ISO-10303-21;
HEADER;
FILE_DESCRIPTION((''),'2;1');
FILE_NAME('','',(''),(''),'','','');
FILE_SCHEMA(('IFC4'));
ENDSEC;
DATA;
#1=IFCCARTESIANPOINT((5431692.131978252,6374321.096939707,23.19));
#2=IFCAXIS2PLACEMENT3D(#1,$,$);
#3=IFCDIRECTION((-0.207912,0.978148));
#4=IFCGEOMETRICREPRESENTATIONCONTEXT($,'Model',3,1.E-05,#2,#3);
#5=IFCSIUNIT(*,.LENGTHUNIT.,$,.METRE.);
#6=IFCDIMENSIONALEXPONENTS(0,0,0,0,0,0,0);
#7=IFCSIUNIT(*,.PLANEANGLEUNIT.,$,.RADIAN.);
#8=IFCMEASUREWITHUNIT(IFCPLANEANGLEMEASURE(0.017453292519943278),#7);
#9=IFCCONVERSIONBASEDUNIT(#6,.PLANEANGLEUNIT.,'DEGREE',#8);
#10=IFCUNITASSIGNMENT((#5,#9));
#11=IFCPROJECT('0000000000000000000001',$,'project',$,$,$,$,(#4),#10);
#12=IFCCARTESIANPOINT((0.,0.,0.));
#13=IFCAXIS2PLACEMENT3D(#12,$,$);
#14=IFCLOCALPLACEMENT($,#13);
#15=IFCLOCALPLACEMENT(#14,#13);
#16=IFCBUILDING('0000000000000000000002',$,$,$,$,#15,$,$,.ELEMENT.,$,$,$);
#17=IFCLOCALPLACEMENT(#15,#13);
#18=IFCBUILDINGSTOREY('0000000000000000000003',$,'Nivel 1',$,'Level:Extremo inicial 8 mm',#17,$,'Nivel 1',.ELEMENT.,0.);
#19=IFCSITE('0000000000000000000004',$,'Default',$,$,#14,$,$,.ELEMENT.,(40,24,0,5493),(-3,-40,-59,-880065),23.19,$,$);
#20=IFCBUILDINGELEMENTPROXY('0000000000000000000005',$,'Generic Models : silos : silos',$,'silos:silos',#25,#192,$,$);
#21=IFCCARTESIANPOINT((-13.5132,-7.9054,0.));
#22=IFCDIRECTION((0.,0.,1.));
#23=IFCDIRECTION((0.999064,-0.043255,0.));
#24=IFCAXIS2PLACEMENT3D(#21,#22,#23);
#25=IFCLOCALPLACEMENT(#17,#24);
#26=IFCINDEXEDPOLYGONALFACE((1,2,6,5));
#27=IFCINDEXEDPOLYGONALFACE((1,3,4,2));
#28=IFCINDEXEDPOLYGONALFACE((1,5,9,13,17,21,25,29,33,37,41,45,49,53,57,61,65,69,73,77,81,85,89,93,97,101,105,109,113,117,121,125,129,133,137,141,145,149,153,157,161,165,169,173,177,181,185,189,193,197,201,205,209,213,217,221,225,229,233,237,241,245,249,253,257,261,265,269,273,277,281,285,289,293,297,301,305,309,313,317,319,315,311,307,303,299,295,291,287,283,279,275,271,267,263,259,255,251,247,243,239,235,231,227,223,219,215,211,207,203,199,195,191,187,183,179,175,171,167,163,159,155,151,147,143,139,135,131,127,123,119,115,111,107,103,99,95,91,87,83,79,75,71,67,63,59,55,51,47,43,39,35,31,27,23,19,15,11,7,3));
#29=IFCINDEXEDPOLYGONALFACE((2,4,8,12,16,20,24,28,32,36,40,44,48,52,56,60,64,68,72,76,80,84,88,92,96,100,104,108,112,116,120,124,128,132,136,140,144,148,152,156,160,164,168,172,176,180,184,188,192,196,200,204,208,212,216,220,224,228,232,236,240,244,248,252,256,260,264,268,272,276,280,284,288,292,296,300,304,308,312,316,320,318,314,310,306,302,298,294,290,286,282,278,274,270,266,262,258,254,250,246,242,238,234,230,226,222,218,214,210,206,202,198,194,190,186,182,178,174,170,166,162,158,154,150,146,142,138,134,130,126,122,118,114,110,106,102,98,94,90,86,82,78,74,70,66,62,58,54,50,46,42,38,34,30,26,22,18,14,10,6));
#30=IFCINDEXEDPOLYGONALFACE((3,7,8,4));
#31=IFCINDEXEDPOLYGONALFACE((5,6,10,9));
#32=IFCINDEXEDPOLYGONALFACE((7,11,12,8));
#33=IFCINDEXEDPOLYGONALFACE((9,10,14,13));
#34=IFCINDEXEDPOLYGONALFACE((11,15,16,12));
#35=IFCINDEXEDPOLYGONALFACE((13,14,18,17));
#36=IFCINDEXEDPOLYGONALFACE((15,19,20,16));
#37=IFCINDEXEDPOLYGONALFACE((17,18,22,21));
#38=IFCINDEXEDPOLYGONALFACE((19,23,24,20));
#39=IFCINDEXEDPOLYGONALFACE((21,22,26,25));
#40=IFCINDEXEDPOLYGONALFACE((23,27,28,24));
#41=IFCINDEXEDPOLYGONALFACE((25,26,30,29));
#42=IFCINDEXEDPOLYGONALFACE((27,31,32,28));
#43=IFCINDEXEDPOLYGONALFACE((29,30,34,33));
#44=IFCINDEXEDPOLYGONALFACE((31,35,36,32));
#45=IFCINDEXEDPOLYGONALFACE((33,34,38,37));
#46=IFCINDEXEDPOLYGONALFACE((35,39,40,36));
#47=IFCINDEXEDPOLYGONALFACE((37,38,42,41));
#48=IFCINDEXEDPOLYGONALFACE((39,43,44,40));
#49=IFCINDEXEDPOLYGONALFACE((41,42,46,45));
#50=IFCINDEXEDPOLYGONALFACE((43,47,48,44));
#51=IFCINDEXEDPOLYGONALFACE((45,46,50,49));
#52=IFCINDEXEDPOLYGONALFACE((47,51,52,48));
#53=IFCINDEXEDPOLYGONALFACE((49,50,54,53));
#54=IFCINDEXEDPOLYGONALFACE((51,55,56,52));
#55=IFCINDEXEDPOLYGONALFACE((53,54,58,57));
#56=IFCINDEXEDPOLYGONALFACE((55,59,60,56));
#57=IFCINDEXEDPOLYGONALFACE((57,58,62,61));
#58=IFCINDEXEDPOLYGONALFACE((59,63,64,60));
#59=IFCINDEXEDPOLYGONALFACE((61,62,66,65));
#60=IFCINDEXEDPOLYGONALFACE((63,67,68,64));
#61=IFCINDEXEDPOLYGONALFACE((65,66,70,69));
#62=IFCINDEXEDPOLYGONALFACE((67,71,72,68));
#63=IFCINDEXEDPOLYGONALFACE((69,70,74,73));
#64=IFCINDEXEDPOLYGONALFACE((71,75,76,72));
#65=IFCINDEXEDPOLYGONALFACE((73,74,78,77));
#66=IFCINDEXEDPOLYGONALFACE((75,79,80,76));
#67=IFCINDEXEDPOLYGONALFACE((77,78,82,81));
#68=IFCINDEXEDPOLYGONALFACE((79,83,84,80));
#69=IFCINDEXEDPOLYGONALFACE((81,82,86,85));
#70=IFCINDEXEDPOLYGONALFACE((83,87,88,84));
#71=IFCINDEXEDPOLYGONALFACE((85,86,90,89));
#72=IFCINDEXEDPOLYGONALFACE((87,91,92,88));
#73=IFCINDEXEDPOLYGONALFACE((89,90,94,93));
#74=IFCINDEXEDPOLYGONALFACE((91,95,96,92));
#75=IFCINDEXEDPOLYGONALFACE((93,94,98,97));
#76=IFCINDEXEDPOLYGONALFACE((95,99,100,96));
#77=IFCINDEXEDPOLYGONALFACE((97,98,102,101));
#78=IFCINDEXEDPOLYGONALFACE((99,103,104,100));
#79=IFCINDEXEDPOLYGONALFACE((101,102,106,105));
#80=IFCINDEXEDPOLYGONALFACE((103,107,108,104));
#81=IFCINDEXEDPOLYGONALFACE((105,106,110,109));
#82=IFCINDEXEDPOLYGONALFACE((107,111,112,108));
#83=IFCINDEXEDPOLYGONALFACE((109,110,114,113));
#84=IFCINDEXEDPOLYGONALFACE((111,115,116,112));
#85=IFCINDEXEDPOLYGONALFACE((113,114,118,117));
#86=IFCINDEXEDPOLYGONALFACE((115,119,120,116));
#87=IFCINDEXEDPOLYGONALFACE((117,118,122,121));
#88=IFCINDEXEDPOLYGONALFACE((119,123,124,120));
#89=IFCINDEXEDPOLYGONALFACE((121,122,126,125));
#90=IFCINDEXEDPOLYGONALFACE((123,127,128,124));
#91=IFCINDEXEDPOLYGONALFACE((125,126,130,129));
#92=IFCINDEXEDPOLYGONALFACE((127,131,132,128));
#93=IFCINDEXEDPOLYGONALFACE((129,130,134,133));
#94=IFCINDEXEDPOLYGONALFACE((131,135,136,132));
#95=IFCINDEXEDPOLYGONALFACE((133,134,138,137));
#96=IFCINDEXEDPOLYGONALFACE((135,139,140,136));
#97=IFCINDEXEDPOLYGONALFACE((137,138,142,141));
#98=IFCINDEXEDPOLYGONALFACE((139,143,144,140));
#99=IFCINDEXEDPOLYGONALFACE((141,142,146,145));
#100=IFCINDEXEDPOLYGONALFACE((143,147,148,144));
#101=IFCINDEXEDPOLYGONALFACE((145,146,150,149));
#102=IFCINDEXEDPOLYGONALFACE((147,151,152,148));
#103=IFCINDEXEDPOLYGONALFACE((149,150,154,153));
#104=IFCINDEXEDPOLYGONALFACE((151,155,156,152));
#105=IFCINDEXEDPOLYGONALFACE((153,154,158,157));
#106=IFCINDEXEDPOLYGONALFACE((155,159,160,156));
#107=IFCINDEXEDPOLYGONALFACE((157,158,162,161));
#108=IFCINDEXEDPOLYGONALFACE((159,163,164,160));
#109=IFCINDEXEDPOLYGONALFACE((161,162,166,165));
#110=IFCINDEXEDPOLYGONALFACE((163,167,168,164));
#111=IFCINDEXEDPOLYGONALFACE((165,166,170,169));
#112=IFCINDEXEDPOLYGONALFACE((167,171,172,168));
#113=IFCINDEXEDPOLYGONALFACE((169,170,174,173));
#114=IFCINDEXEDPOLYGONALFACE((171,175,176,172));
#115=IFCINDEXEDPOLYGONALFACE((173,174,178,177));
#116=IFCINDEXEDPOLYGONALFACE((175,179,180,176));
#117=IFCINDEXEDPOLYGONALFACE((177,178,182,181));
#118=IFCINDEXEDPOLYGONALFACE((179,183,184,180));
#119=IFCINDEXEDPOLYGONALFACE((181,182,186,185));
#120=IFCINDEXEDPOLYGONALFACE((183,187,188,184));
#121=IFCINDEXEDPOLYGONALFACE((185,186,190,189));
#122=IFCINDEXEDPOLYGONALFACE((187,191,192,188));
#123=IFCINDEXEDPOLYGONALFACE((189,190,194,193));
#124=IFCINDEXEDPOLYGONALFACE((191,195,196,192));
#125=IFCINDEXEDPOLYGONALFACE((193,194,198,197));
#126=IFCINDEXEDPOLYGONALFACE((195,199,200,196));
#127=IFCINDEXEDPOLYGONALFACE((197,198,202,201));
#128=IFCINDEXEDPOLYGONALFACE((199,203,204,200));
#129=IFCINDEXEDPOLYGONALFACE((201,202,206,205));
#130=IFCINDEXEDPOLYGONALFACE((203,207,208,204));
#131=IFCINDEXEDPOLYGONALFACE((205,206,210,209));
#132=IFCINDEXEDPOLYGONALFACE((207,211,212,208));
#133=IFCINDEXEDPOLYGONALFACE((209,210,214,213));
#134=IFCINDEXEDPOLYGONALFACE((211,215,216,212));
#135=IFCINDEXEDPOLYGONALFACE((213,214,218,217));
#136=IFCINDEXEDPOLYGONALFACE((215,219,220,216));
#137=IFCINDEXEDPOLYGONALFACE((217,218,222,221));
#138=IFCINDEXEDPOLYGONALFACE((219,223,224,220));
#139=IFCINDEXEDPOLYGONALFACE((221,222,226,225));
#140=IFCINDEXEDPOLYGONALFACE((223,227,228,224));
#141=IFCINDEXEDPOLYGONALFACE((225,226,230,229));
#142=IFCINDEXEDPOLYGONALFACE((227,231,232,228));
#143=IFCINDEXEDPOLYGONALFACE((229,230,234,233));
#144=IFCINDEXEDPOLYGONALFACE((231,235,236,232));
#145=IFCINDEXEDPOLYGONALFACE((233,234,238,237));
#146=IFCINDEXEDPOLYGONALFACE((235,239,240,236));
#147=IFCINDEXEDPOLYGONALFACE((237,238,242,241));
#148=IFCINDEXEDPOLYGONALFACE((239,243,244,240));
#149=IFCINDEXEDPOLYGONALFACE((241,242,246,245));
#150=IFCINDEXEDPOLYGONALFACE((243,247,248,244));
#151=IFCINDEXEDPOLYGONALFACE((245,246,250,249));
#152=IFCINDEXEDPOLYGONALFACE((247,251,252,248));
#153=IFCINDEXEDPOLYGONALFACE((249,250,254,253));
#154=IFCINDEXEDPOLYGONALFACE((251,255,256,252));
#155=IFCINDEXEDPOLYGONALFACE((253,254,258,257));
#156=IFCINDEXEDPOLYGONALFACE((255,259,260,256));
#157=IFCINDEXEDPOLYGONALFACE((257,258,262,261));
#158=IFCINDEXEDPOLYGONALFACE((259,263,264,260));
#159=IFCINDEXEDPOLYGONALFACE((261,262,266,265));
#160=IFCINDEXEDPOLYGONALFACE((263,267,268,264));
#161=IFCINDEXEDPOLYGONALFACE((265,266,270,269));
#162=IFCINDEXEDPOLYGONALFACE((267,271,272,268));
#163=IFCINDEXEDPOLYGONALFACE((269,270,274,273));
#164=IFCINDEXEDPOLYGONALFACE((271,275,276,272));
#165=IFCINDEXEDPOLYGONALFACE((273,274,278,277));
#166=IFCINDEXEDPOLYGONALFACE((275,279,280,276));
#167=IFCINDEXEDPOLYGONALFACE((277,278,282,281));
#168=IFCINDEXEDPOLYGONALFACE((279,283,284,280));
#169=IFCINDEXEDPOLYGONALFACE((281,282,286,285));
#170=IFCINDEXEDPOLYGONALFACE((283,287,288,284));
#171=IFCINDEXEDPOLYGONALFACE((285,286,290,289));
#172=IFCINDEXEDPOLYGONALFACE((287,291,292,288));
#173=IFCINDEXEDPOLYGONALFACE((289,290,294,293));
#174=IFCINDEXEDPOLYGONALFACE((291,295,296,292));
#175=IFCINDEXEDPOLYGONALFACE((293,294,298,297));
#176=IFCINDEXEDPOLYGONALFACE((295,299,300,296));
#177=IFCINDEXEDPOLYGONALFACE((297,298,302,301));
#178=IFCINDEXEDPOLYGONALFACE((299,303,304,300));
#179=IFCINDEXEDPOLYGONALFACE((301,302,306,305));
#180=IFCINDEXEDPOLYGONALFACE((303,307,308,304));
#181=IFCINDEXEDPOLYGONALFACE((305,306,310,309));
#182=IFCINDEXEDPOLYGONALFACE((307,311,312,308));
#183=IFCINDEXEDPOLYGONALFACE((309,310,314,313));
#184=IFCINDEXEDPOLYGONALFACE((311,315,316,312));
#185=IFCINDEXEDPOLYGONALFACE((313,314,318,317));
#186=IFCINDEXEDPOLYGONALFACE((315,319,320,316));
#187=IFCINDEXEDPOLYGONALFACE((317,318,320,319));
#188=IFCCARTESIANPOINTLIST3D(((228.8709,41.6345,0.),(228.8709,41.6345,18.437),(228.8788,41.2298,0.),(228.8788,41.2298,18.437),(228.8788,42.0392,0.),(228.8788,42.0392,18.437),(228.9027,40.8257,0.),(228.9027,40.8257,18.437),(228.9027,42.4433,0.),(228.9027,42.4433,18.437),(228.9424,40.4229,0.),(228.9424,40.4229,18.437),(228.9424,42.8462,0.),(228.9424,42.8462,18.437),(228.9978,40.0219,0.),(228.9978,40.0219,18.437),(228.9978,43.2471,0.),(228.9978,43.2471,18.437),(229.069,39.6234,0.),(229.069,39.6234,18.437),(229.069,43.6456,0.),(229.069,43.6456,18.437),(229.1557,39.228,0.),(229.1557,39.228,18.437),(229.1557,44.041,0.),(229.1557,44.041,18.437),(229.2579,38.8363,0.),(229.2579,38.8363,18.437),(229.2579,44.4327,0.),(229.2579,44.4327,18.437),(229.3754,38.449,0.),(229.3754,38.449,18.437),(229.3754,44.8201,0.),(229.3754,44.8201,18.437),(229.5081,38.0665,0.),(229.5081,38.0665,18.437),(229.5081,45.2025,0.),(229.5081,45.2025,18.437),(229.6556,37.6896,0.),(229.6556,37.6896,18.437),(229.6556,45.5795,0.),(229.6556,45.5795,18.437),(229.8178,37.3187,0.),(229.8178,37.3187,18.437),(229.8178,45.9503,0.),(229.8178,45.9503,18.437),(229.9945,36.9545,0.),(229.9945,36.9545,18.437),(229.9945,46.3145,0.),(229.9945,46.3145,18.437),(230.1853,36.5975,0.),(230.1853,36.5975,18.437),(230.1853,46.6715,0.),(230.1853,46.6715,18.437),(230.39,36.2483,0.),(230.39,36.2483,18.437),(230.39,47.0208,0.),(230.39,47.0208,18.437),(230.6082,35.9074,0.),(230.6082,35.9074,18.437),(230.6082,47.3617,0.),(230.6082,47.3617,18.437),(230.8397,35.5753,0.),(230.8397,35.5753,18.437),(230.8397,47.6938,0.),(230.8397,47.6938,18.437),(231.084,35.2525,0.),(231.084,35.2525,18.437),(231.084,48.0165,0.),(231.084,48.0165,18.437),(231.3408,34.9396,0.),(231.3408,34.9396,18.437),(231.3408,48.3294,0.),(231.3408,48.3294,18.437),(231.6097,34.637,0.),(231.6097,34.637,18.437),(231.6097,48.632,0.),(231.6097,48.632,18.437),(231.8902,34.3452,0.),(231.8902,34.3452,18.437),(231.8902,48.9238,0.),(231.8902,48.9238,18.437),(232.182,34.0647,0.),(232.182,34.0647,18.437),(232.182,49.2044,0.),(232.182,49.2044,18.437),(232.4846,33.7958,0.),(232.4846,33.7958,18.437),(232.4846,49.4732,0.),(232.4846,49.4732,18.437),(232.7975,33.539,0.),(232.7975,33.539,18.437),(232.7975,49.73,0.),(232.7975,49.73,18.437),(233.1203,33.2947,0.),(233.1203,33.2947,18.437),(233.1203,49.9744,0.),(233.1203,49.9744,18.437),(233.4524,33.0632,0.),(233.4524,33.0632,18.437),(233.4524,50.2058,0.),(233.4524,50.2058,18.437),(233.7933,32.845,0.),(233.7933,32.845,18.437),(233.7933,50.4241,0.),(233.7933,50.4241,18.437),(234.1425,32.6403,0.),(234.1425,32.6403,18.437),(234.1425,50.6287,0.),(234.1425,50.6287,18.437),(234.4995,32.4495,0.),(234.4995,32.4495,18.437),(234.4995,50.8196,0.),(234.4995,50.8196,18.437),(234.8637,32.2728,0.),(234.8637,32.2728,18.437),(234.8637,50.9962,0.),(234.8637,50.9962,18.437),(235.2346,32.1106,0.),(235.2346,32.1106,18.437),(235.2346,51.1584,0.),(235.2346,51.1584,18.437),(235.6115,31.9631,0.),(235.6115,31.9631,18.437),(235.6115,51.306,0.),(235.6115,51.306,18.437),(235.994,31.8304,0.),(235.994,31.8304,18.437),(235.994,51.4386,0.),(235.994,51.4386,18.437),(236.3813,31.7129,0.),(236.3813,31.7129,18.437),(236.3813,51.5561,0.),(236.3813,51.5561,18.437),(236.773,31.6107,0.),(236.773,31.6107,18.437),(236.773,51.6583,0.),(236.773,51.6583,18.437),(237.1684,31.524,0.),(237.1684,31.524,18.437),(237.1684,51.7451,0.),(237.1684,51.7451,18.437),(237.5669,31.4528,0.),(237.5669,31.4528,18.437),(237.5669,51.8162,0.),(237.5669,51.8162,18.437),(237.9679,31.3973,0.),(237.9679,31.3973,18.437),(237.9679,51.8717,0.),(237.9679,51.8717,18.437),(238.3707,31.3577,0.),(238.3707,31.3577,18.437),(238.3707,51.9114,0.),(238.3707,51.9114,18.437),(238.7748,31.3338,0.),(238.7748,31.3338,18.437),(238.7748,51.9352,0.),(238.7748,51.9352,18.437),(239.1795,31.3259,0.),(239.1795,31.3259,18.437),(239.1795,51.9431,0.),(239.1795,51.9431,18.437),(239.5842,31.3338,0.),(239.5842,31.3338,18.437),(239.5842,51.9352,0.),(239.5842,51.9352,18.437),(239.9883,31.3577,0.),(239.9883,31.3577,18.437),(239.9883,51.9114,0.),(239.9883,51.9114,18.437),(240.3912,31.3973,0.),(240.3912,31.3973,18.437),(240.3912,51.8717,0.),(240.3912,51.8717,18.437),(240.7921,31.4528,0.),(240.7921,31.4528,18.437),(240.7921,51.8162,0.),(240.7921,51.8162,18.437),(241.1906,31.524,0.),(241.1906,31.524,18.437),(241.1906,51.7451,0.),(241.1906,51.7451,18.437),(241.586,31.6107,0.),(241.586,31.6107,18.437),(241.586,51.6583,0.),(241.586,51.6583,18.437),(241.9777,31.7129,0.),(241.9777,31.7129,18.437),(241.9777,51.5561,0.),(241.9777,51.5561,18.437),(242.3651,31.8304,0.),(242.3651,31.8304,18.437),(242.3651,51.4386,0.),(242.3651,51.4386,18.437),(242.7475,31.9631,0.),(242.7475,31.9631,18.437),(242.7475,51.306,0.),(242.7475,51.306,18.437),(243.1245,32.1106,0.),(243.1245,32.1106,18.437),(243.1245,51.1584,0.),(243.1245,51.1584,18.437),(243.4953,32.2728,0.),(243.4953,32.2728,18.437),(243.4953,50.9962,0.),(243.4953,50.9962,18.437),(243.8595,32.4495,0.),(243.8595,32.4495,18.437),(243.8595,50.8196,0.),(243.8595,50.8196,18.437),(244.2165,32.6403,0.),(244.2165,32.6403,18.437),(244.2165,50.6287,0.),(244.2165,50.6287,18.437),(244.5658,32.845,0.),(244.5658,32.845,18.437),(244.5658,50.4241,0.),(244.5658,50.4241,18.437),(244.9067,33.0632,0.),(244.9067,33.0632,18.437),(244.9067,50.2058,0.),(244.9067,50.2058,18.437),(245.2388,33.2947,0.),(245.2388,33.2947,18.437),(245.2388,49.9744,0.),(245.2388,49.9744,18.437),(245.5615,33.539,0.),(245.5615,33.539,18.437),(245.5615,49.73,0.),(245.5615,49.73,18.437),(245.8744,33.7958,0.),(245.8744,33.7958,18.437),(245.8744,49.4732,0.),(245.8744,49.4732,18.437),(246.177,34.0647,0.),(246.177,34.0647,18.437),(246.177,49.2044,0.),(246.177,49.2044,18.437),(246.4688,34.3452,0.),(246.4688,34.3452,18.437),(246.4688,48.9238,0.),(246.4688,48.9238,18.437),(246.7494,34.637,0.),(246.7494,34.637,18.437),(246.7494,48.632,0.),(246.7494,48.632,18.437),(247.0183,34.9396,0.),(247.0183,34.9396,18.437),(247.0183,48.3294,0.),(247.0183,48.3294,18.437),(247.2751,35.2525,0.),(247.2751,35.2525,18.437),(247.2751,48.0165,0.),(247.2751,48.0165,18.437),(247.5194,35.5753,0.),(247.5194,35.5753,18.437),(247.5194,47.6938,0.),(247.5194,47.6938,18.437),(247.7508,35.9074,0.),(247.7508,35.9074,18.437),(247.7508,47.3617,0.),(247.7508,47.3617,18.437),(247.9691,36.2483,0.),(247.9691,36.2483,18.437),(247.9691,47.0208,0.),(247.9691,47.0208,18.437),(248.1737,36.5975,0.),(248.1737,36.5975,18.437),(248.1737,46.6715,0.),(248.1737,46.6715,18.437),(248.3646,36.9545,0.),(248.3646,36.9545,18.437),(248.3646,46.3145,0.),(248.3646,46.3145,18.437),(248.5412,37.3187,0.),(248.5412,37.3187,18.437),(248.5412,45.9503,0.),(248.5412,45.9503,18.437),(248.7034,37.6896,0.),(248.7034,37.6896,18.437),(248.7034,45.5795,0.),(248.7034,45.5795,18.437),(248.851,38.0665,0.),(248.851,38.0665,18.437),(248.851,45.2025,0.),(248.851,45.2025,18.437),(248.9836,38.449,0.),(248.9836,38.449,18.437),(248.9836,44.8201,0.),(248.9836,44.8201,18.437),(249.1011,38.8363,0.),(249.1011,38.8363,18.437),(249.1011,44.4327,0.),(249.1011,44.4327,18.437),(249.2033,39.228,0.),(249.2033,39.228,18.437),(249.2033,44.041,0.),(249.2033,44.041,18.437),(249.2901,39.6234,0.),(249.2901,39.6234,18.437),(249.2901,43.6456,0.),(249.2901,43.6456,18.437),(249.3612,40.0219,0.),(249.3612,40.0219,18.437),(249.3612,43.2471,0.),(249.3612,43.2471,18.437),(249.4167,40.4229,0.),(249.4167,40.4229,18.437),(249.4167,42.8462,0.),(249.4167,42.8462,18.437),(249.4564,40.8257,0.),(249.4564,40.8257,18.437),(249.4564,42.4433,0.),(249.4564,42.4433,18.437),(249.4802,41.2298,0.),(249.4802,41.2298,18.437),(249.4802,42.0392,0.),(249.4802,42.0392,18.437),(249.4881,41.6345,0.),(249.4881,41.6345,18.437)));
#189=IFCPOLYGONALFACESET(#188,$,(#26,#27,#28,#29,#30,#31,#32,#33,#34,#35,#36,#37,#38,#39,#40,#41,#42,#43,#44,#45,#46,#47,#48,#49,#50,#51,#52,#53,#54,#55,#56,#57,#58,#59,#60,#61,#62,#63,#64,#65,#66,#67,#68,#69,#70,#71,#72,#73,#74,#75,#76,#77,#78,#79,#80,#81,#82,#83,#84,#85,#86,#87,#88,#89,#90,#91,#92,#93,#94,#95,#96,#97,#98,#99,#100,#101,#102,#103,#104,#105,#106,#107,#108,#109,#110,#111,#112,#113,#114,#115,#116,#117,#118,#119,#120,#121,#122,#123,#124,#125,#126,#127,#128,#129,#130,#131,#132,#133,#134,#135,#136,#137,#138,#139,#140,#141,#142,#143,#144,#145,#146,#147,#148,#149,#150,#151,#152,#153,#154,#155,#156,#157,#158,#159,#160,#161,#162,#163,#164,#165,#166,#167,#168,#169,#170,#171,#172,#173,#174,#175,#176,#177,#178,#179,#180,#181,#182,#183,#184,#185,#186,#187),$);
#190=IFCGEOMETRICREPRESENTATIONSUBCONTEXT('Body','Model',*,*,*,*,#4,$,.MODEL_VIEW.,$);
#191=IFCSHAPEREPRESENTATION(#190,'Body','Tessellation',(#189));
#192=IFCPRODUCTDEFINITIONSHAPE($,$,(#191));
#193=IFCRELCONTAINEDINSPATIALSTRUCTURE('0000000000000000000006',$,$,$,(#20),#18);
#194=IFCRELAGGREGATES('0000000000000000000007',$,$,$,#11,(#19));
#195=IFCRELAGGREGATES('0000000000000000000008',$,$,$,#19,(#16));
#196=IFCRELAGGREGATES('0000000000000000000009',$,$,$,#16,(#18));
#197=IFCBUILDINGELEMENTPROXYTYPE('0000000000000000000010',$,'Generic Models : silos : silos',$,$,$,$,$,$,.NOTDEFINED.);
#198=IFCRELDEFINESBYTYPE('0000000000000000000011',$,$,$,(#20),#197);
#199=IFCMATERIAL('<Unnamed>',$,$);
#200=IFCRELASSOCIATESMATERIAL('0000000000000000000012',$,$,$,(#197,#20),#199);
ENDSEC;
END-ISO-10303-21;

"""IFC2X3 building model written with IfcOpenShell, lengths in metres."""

from ifc_helpers import new_model, entity, si_unit, converted_unit, direction, frame, frame_2d, origin, place, context, subcontext, project, spatial, circle, extrude, source, transform, mapped, material, type_object, type_shapes, element, save


model = new_model("IFC2X3")

# Units and contexts
model_context = context("Model", 3, precision=1e-05, world=frame((5431692.131978252, 6374321.096939707, 23.19)), true_north=direction((-0.207912, 0.978148)))
body_context = subcontext(model_context, "Body", "Model", "MODEL_VIEW")
ifc_project = project(units=[si_unit("LENGTHUNIT", "METRE"), converted_unit("PLANEANGLEUNIT", "DEGREE", entity("IfcPlaneAngleMeasure", 0.017453292519943278), si_unit("PLANEANGLEUNIT", "RADIAN"), dimensions=[0, 0, 0, 0, 0, 0, 0])], contexts=[model_context])

# Site, building, storey
site_placement = place(None, origin())
site = spatial("IfcSite", under=ifc_project, at=site_placement, Name="Default", CompositionType="ELEMENT", RefLatitude=(40, 24, 0, 5493), RefLongitude=(-3, -40, -59, -880065), RefElevation=23.19)
building_placement = place(site_placement, origin())
building = spatial("IfcBuilding", under=site, at=building_placement, CompositionType="ELEMENT")
storey_placement = place(building_placement, origin())
storey = spatial("IfcBuildingStorey", under=building, at=storey_placement, Name="Nivel 1", ObjectType="Level:Extremo inicial 8 mm", LongName="Nivel 1", CompositionType="ELEMENT", Elevation=0.0)

# Building element proxy
ifc_material_1 = material(Name="<Unnamed>")
building_element_proxy_type_1 = type_object("IfcBuildingElementProxyType", Name="Generic Models : silos : silos", PredefinedType="NOTDEFINED", material=ifc_material_1)
shared_shape_1 = source(origin(), body_context, "Body", "SweptSolid", [
    extrude(circle(Radius=10.3086, at=frame_2d((0.0, 0.0), x_axis=(1.0, 0.0))), frame((239.1795, 41.6345, 0.0)), (0.0, 0.0, 1.0), 18.437),
])
type_shapes(building_element_proxy_type_1, [shared_shape_1])
proxy_1_placement = place(storey_placement, frame((-13.5132, -7.9054, 0.0), z_axis=(0.0, 0.0, 1.0), x_axis=(0.999064, -0.043255, 0.0)))
element("IfcBuildingElementProxy", 1, at=proxy_1_placement, inside=storey, type_object=building_element_proxy_type_1, material=ifc_material_1, Name="Generic Models : silos : silos", ObjectType="silos:silos", context=body_context, shape_type="MappedRepresentation", body=[
    mapped(shared_shape_1, transform((0.0, 0.0, 0.0), scale=1.0)),
])

save(model, "model.ifc")
